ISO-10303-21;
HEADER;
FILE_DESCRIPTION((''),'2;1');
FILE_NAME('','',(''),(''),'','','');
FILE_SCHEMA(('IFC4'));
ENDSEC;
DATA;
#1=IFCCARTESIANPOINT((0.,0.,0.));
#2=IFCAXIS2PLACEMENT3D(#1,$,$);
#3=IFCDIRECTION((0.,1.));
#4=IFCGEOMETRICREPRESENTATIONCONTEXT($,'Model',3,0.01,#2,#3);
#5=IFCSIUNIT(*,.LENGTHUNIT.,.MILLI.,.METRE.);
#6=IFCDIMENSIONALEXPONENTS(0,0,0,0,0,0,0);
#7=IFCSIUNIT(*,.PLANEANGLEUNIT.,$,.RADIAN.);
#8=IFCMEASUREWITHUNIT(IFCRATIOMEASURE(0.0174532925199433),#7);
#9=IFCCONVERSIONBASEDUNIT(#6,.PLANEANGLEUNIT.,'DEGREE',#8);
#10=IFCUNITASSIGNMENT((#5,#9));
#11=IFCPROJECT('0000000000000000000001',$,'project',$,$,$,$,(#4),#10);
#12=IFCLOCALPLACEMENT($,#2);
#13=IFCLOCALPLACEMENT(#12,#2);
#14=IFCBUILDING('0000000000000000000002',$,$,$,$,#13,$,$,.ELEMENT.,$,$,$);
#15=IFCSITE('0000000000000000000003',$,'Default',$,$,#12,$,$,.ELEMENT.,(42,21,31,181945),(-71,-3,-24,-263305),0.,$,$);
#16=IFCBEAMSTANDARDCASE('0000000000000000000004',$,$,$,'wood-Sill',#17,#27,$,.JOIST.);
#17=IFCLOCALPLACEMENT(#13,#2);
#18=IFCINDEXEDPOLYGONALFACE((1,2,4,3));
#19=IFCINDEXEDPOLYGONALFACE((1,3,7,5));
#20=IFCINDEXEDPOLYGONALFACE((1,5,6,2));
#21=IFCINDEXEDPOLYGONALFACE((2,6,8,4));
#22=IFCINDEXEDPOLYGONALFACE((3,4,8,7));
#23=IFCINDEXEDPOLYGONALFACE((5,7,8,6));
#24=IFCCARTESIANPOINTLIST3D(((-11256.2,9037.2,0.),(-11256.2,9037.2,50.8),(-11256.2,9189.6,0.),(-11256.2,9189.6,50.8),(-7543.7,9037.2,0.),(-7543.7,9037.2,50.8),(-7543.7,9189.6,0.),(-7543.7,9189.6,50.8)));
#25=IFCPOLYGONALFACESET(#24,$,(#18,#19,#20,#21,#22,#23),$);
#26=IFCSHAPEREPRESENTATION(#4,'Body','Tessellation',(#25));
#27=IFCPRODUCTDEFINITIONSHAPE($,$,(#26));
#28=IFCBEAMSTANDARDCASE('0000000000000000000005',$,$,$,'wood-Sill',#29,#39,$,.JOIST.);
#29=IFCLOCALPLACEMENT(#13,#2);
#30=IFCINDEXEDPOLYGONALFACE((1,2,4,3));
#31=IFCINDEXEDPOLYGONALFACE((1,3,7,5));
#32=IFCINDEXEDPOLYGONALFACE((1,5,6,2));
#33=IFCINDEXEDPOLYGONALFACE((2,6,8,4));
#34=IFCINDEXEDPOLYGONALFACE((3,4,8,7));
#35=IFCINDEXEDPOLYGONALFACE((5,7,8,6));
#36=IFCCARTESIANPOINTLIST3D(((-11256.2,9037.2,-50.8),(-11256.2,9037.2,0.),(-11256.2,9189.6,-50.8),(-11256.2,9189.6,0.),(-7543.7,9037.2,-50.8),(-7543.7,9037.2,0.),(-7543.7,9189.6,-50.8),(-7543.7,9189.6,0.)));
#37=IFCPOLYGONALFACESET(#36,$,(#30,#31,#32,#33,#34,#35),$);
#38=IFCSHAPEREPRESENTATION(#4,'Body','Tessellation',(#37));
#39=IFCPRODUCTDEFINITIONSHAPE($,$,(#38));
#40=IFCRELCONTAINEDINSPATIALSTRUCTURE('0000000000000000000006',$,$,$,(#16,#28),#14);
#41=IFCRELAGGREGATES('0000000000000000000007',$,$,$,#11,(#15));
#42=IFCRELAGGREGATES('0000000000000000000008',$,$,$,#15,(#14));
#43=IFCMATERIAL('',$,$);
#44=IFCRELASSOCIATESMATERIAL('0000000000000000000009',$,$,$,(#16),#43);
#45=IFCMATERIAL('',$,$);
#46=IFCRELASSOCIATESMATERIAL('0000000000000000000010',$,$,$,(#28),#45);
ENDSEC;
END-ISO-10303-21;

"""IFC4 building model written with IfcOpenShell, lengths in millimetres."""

from ifc_helpers import new_model, entity, si_unit, converted_unit, direction, frame, origin, place, context, project, spatial, rectangle, extrude, material, element, save


model = new_model("IFC4")

# Units and contexts
model_context = context("Model", 3, precision=0.01, world=origin(), true_north=direction((0.0, 1.0)))
ifc_project = project(units=[si_unit("LENGTHUNIT", "METRE", prefix="MILLI"), converted_unit("PLANEANGLEUNIT", "DEGREE", entity("IfcRatioMeasure", 0.0174532925199433), si_unit("PLANEANGLEUNIT", "RADIAN"), dimensions=[0, 0, 0, 0, 0, 0, 0])], contexts=[model_context])

# Site, building
site_placement = place(None, origin())
site = spatial("IfcSite", under=ifc_project, at=site_placement, Name="Default", CompositionType="ELEMENT", RefLatitude=(42, 21, 31, 181945), RefLongitude=(-71, -3, -24, -263305), RefElevation=0.0)
building_placement = place(site_placement, origin())
building = spatial("IfcBuilding", under=site, at=building_placement, CompositionType="ELEMENT")

# Shared definitions
placement_1 = place(building_placement, origin())

# Beams
ifc_material_1 = material(Name="")
placement_2 = place(placement_1, frame((-9399.9, 7257.2, 0.0), z_axis=(0.0, 0.0, 1.0), x_axis=(0.0, 1.0, 0.0)))
beam_1_placement = place(placement_2, frame((1856.2, 0.0, 0.0), z_axis=(0.0, 0.0, 1.0), x_axis=(0.0, 1.0, 0.0)))
element("IfcBeamStandardCase", 1, at=beam_1_placement, inside=building, material=ifc_material_1, ObjectType="wood-Sill", PredefinedType="JOIST", context=model_context, shape_type="SweptSolid", body=[
    extrude(rectangle(XDim=3712.5, YDim=152.4), origin(), (0.0, 0.0, 1.0), 50.8),
])
ifc_material_2 = material(Name="")
beam_2_placement = place(placement_2, frame((1856.2, 0.0, -50.8), z_axis=(0.0, 0.0, 1.0), x_axis=(0.0, 1.0, 0.0)))
element("IfcBeamStandardCase", 2, at=beam_2_placement, inside=building, material=ifc_material_2, ObjectType="wood-Sill", PredefinedType="JOIST", context=model_context, shape_type="SweptSolid", body=[
    extrude(rectangle(XDim=3712.5, YDim=152.4), origin(), (0.0, 0.0, 1.0), 50.8),
])

save(model, "model.ifc")
